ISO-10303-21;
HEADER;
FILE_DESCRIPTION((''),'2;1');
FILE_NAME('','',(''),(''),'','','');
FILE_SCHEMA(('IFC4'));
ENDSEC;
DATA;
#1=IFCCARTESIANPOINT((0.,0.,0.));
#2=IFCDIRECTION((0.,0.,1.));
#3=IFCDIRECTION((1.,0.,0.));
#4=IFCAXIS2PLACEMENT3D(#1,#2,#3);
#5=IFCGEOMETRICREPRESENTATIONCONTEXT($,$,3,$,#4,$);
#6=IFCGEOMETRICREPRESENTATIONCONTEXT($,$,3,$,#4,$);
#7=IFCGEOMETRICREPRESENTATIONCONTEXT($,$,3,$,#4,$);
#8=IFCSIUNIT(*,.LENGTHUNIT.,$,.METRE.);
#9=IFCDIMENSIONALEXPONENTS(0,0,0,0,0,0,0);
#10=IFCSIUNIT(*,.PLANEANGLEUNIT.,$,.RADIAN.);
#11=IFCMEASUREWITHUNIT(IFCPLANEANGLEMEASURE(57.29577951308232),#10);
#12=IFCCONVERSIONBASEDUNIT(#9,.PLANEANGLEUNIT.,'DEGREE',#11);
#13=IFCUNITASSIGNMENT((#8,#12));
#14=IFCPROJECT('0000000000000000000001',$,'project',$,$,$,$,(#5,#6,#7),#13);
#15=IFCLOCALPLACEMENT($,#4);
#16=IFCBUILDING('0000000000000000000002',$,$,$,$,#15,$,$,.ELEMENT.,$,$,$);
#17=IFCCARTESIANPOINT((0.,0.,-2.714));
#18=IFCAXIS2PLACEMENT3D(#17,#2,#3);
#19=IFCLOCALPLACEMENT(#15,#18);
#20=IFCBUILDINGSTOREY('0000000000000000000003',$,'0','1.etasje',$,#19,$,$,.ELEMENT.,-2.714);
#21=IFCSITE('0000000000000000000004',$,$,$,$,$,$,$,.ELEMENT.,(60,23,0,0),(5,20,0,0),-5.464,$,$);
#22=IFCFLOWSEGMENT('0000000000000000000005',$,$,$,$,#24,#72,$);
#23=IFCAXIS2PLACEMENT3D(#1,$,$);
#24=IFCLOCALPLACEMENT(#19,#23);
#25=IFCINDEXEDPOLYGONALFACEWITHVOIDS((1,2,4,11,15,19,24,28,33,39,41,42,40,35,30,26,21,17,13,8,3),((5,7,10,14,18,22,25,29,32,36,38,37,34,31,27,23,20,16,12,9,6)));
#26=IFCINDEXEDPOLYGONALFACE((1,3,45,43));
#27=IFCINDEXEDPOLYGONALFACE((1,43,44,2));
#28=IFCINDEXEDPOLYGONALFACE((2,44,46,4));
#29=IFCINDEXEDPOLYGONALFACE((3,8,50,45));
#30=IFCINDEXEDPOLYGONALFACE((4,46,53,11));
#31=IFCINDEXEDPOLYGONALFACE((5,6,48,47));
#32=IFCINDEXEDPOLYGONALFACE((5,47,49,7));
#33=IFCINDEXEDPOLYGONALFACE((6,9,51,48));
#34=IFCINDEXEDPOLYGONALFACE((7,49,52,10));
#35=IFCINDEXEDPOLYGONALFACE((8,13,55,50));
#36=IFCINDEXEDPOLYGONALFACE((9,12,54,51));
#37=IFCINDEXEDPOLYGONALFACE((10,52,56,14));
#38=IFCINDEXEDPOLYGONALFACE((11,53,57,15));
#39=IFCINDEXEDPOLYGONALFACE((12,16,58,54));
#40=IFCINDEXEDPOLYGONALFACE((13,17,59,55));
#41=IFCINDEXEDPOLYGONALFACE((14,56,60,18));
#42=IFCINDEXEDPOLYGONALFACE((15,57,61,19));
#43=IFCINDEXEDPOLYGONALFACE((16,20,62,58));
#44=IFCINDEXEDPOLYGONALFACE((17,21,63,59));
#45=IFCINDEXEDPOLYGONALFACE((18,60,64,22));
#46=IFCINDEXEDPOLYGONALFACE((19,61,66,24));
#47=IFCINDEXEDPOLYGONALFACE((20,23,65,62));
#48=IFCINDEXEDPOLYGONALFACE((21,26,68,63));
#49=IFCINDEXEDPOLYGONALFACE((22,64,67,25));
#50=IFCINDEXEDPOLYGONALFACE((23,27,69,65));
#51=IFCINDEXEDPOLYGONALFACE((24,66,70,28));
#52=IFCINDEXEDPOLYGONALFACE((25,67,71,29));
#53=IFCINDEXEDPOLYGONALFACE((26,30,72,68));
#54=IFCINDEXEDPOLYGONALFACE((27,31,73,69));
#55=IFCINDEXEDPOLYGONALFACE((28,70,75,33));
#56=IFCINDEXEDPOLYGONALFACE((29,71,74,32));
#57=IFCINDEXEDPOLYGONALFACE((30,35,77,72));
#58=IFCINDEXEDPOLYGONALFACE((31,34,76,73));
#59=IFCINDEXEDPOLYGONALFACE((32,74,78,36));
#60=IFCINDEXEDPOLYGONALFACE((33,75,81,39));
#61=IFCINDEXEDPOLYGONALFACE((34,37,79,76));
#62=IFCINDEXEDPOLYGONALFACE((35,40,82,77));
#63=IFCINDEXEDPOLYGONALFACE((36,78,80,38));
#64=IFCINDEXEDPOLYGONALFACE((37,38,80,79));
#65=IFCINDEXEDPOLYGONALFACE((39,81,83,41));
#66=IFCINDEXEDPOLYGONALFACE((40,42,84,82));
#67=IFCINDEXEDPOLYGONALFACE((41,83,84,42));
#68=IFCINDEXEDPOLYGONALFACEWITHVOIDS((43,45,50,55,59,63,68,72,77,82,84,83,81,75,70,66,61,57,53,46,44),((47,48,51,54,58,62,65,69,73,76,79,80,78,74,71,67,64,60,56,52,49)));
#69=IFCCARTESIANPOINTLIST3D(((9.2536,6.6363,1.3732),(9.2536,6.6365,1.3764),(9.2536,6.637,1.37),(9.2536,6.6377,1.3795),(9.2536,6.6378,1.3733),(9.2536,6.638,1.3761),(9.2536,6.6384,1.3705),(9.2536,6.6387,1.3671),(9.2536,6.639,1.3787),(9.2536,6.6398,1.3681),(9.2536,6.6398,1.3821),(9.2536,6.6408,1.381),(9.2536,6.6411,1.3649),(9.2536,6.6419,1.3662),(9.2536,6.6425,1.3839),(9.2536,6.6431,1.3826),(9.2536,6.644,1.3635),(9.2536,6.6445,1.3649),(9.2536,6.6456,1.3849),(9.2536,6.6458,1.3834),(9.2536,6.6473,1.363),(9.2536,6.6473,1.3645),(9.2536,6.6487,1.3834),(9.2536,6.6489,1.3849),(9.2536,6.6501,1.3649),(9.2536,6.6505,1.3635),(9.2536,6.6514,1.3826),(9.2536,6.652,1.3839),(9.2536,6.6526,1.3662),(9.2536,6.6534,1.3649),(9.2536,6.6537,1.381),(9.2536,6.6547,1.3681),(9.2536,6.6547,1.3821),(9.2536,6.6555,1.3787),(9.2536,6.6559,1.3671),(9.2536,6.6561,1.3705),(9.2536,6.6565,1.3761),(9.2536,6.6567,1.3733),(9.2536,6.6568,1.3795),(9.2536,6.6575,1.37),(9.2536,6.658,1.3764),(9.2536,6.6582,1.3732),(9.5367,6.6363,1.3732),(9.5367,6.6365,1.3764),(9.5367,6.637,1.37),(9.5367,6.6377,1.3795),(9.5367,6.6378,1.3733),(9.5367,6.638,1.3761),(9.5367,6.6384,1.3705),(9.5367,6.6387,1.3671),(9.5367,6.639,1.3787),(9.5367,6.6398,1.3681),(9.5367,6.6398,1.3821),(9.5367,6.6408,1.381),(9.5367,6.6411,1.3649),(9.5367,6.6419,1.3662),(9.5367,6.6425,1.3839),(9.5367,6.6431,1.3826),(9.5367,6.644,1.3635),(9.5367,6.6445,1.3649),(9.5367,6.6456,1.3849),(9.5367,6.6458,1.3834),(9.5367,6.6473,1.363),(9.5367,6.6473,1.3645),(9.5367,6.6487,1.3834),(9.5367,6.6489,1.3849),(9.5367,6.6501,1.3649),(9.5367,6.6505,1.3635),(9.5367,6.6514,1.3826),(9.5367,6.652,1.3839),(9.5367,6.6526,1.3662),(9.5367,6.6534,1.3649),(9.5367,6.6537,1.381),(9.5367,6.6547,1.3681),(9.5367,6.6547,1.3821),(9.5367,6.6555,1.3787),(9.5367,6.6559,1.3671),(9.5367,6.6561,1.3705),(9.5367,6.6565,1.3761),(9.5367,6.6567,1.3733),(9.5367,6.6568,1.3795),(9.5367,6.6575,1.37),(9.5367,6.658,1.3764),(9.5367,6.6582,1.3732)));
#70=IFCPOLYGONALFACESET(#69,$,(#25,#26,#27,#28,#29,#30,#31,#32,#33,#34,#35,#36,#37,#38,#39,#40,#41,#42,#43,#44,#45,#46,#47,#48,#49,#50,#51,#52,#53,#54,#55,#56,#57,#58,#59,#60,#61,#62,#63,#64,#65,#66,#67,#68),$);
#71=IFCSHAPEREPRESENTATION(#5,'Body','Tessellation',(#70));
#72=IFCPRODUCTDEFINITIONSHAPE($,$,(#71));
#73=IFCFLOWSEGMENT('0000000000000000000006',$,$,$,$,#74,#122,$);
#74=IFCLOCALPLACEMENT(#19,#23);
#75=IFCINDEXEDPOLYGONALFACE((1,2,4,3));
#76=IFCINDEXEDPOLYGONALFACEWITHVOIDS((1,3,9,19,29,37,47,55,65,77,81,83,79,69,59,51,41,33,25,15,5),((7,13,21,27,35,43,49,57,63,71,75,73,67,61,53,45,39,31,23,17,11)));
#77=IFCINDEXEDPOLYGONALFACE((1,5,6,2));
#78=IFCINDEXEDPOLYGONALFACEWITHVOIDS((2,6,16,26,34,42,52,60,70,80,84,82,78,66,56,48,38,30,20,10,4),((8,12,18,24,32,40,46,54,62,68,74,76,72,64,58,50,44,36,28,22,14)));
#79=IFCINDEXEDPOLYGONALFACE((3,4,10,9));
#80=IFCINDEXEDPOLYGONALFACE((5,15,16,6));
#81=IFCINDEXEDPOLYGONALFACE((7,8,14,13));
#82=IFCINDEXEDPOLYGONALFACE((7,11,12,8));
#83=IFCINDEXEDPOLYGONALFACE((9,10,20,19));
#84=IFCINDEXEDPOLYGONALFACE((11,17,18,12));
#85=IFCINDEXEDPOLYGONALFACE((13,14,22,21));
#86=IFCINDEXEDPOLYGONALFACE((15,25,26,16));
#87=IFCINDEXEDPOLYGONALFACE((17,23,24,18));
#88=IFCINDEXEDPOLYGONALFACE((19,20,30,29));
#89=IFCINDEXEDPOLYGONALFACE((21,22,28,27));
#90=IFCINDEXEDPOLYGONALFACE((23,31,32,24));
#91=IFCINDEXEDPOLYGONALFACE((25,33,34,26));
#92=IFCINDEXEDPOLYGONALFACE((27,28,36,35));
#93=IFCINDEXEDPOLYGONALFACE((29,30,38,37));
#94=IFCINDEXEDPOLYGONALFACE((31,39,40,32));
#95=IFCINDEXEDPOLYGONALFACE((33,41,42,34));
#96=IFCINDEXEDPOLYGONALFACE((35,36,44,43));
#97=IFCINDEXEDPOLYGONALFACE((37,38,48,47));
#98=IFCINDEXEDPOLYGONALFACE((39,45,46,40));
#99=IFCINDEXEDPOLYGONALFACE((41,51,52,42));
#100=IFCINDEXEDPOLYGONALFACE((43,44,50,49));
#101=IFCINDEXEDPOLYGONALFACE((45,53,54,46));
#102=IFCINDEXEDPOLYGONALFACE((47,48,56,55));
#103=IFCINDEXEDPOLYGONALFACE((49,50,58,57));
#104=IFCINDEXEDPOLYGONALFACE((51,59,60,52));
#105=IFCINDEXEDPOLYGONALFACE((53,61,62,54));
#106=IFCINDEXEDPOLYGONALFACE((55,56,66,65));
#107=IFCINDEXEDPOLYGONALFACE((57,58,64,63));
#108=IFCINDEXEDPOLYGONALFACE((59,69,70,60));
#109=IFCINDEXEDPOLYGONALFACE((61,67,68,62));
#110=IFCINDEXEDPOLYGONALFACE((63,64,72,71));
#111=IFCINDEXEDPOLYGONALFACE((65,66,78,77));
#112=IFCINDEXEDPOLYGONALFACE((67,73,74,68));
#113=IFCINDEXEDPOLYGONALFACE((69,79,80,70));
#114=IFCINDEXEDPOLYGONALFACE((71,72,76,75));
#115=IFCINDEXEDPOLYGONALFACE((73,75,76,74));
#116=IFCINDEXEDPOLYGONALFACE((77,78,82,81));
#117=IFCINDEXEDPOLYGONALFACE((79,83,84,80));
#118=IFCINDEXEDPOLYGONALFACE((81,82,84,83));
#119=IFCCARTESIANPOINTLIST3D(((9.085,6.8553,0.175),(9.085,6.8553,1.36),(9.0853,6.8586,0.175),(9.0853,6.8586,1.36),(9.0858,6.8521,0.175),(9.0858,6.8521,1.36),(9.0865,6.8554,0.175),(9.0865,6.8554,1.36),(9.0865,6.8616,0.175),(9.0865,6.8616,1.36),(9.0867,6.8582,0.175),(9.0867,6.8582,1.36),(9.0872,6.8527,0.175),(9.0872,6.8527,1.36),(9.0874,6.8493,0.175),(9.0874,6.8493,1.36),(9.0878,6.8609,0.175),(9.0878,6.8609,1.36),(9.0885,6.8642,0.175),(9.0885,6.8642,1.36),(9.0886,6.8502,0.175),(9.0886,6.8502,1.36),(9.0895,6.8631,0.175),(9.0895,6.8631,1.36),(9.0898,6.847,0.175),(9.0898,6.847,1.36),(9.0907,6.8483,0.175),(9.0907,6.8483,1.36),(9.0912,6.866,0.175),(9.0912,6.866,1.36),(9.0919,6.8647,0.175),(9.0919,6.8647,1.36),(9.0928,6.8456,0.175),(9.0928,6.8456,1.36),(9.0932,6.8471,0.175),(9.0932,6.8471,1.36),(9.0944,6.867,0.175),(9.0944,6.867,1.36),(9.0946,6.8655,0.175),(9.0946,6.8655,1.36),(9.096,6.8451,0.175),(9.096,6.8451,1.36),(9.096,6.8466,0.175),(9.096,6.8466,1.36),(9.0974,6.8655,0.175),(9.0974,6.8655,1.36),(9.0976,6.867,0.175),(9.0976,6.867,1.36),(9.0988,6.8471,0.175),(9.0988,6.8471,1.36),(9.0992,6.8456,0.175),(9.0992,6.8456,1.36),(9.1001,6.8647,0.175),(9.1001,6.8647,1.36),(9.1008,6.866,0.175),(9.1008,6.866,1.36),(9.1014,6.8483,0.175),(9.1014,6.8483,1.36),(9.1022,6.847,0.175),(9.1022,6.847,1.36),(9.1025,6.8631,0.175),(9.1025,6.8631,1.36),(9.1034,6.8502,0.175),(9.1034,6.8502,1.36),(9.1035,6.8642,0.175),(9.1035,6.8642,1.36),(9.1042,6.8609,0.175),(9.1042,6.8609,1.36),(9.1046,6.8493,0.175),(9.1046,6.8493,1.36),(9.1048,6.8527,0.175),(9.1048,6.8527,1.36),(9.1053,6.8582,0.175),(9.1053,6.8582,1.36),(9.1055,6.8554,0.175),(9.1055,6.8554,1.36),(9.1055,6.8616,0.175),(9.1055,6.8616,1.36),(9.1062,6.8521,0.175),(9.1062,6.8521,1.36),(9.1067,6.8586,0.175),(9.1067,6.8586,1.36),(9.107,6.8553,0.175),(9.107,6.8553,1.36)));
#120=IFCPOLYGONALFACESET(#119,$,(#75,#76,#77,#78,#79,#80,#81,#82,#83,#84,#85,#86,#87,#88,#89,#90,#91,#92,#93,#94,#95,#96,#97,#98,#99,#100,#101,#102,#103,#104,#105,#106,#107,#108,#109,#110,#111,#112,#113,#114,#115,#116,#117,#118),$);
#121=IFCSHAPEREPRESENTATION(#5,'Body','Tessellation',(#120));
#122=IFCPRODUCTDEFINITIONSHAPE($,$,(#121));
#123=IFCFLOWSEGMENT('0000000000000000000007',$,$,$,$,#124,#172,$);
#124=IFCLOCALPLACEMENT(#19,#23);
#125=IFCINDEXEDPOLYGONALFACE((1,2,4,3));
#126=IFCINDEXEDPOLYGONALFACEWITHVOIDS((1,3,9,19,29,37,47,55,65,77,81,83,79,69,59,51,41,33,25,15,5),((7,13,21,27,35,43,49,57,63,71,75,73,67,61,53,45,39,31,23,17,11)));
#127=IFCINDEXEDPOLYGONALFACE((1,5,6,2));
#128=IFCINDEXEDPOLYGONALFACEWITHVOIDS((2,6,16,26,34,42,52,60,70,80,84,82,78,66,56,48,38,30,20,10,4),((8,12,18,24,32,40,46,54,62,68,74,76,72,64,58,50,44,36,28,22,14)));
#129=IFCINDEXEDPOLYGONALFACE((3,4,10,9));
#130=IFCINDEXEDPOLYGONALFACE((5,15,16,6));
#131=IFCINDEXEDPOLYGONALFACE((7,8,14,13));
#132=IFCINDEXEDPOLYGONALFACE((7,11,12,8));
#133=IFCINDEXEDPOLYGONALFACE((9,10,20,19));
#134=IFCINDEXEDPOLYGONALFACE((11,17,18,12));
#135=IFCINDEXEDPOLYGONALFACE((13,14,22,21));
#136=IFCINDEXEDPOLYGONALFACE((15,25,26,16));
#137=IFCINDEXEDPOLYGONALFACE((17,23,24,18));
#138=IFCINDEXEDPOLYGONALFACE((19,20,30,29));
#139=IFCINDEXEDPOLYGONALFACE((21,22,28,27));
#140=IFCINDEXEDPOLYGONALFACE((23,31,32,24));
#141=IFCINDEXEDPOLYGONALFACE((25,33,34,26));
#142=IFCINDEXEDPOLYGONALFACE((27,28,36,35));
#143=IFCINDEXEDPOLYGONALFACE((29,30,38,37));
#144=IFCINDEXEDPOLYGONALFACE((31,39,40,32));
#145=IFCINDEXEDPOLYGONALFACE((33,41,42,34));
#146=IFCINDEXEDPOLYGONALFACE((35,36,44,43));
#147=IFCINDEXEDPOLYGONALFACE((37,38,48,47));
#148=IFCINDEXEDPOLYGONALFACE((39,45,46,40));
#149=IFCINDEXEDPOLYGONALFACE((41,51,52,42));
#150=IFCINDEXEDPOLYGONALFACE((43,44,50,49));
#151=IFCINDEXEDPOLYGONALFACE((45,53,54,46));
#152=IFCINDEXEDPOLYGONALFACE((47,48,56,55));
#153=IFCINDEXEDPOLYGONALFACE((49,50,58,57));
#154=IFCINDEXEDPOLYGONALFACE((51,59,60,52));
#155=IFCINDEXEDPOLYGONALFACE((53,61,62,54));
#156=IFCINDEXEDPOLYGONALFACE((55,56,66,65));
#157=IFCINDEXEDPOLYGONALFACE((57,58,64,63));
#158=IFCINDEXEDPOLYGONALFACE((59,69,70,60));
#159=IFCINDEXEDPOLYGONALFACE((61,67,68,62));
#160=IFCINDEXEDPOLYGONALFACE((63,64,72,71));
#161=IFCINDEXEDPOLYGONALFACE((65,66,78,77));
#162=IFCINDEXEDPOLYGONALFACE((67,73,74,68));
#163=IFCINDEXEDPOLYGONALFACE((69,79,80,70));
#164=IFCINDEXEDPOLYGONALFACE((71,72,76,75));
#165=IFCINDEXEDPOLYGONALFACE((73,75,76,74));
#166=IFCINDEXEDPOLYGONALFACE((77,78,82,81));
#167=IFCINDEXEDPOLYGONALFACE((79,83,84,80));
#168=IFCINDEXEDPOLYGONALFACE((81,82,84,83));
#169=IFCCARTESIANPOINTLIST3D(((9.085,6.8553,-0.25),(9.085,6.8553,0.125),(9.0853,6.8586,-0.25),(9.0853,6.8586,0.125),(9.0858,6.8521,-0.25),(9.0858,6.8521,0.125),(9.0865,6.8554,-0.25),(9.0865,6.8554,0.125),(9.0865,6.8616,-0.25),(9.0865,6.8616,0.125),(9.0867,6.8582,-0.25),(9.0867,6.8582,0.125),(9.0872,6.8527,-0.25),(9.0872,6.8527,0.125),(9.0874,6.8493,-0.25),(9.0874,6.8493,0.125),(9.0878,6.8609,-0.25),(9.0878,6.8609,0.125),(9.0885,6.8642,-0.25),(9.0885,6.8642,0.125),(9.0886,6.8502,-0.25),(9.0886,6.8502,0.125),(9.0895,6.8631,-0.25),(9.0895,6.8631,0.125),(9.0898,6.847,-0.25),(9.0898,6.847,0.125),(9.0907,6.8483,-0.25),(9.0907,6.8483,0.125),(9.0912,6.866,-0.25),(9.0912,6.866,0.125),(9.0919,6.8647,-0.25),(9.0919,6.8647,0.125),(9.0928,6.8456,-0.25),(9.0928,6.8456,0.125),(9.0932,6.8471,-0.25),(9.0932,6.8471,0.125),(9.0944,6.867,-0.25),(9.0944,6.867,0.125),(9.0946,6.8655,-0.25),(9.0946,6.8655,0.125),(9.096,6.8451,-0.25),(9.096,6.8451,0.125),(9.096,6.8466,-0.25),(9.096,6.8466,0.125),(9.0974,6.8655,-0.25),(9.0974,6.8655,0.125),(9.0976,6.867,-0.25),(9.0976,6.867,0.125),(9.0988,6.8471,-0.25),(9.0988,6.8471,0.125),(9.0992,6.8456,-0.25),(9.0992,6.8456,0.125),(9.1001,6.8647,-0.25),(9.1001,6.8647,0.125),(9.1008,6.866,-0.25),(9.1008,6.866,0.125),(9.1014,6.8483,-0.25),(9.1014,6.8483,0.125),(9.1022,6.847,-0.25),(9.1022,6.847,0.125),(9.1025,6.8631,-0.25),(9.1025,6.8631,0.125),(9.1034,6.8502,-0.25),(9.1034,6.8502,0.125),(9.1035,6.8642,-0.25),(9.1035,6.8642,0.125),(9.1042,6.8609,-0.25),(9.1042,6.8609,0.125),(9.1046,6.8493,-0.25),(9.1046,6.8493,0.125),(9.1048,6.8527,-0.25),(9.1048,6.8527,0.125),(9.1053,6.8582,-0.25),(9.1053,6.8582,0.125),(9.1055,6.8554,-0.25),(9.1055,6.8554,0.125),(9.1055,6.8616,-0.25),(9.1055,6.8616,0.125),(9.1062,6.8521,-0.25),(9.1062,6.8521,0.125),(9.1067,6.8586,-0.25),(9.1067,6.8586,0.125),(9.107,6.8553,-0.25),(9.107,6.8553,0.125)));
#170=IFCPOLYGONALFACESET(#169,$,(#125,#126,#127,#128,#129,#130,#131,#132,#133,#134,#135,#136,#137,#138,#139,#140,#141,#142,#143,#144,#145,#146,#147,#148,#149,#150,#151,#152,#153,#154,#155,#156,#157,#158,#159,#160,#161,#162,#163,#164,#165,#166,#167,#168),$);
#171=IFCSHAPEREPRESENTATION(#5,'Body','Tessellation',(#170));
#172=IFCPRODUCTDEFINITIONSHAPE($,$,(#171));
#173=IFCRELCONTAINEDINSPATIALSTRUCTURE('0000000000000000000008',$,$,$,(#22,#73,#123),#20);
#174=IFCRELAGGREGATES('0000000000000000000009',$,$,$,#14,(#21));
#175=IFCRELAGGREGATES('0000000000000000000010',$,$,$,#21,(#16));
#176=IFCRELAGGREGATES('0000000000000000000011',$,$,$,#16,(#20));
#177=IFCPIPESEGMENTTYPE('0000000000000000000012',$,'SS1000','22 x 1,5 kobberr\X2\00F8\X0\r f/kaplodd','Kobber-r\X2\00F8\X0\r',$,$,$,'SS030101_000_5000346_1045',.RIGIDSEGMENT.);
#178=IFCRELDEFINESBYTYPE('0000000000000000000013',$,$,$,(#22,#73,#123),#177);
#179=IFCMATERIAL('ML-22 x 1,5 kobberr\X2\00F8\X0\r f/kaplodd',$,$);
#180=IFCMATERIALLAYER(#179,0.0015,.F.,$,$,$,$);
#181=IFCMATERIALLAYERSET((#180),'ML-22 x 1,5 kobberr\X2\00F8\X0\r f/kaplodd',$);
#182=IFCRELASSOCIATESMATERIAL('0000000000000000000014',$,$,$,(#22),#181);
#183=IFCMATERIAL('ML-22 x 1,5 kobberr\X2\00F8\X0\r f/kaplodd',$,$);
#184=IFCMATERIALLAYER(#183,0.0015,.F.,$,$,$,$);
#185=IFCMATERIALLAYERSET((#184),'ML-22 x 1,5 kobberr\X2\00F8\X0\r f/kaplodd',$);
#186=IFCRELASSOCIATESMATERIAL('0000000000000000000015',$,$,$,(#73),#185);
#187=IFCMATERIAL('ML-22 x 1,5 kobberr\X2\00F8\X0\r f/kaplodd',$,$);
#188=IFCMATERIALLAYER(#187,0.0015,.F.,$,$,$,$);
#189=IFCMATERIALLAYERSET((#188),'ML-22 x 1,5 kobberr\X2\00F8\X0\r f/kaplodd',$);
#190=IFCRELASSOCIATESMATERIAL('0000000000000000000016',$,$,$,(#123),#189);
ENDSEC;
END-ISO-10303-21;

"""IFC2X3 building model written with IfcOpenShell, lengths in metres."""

from ifc_helpers import new_model, entity, si_unit, converted_unit, frame, origin_with_axes, origin_2d_with_axis, place, context, project, spatial, hollow_circle, extrude, material, layer, layer_set, layer_usage, type_object, element, save


model = new_model("IFC2X3")

# Units and contexts
context_of_model_1 = context(None, 3, world=origin_with_axes())
context_of_model_2 = context(None, 3, world=origin_with_axes())
context_of_model_3 = context(None, 3, world=origin_with_axes())
ifc_project = project(units=[si_unit("LENGTHUNIT", "METRE"), converted_unit("PLANEANGLEUNIT", "DEGREE", entity("IfcPlaneAngleMeasure", 57.29577951308232), si_unit("PLANEANGLEUNIT", "RADIAN"), dimensions=[0, 0, 0, 0, 0, 0, 0])], contexts=[context_of_model_1, context_of_model_2, context_of_model_3])

# Site, building, storey
site = spatial("IfcSite", under=ifc_project, CompositionType="ELEMENT", RefLatitude=(60, 23, 0, 0), RefLongitude=(5, 20, 0, 0), RefElevation=-5.464)
building_placement = place(None, origin_with_axes())
building = spatial("IfcBuilding", under=site, at=building_placement, CompositionType="ELEMENT")
storey_placement = place(building_placement, frame((0.0, 0.0, -2.714), z_axis=(0.0, 0.0, 1.0), x_axis=(1.0, 0.0, 0.0)))
storey = spatial("IfcBuildingStorey", under=building, at=storey_placement, Name="0", Description="1.etasje", CompositionType="ELEMENT", Elevation=-2.714)

# Flow segments
pipe_segment_type_1 = type_object("IfcPipeSegmentType", Name="SS1000", Description="22 x 1,5 kobberrør f/kaplodd", ApplicableOccurrence="Kobber-rør", ElementType="SS030101_000_5000346_1045", PredefinedType="RIGIDSEGMENT")
ifc_material_1 = material(Name="ML-22 x 1,5 kobberrør f/kaplodd")
ifc_layer_1 = layer(ifc_material_1, 0.0015, ventilated=False)
ifc_layer_set_1 = layer_set([ifc_layer_1], Name="ML-22 x 1,5 kobberrør f/kaplodd")
ifc_layer_usage_1 = layer_usage(ifc_layer_set_1, "AXIS2", "POSITIVE", 0.0)
flow_segment_1_placement = place(storey_placement, frame((9.2536, 6.6473, 1.374), z_axis=(1.0, 0.0, 0.0), x_axis=(0.0, 0.0, -1.0)))
element("IfcFlowSegment", 1, at=flow_segment_1_placement, inside=storey, type_object=pipe_segment_type_1, material=ifc_layer_usage_1, context=context_of_model_1, shape_type="SweptSolid", body=[
    extrude(hollow_circle(Radius=0.011, WallThickness=0.0015, at=origin_2d_with_axis()), origin_with_axes(), (0.0, 0.0, 1.0), 0.2831),
])
ifc_material_2 = material(Name="ML-22 x 1,5 kobberrør f/kaplodd")
ifc_layer_2 = layer(ifc_material_2, 0.0015, ventilated=False)
ifc_layer_set_2 = layer_set([ifc_layer_2], Name="ML-22 x 1,5 kobberrør f/kaplodd")
ifc_layer_usage_2 = layer_usage(ifc_layer_set_2, "AXIS2", "POSITIVE", 0.0)
flow_segment_2_placement = place(storey_placement, frame((9.096, 6.8561, 1.36), z_axis=(0.0, 0.0, -1.0), x_axis=(0.0, -1.0, 0.0)))
element("IfcFlowSegment", 2, at=flow_segment_2_placement, inside=storey, type_object=pipe_segment_type_1, material=ifc_layer_usage_2, context=context_of_model_1, shape_type="SweptSolid", body=[
    extrude(hollow_circle(Radius=0.011, WallThickness=0.0015, at=origin_2d_with_axis()), origin_with_axes(), (0.0, 0.0, 1.0), 1.185),
])
ifc_material_3 = material(Name="ML-22 x 1,5 kobberrør f/kaplodd")
ifc_layer_3 = layer(ifc_material_3, 0.0015, ventilated=False)
ifc_layer_set_3 = layer_set([ifc_layer_3], Name="ML-22 x 1,5 kobberrør f/kaplodd")
ifc_layer_usage_3 = layer_usage(ifc_layer_set_3, "AXIS2", "POSITIVE", 0.0)
flow_segment_3_placement = place(storey_placement, frame((9.096, 6.8561, 0.125), z_axis=(0.0, 0.0, -1.0), x_axis=(0.0, -1.0, 0.0)))
element("IfcFlowSegment", 3, at=flow_segment_3_placement, inside=storey, type_object=pipe_segment_type_1, material=ifc_layer_usage_3, context=context_of_model_1, shape_type="SweptSolid", body=[
    extrude(hollow_circle(Radius=0.011, WallThickness=0.0015, at=origin_2d_with_axis()), origin_with_axes(), (0.0, 0.0, 1.0), 0.375),
])

save(model, "model.ifc")
